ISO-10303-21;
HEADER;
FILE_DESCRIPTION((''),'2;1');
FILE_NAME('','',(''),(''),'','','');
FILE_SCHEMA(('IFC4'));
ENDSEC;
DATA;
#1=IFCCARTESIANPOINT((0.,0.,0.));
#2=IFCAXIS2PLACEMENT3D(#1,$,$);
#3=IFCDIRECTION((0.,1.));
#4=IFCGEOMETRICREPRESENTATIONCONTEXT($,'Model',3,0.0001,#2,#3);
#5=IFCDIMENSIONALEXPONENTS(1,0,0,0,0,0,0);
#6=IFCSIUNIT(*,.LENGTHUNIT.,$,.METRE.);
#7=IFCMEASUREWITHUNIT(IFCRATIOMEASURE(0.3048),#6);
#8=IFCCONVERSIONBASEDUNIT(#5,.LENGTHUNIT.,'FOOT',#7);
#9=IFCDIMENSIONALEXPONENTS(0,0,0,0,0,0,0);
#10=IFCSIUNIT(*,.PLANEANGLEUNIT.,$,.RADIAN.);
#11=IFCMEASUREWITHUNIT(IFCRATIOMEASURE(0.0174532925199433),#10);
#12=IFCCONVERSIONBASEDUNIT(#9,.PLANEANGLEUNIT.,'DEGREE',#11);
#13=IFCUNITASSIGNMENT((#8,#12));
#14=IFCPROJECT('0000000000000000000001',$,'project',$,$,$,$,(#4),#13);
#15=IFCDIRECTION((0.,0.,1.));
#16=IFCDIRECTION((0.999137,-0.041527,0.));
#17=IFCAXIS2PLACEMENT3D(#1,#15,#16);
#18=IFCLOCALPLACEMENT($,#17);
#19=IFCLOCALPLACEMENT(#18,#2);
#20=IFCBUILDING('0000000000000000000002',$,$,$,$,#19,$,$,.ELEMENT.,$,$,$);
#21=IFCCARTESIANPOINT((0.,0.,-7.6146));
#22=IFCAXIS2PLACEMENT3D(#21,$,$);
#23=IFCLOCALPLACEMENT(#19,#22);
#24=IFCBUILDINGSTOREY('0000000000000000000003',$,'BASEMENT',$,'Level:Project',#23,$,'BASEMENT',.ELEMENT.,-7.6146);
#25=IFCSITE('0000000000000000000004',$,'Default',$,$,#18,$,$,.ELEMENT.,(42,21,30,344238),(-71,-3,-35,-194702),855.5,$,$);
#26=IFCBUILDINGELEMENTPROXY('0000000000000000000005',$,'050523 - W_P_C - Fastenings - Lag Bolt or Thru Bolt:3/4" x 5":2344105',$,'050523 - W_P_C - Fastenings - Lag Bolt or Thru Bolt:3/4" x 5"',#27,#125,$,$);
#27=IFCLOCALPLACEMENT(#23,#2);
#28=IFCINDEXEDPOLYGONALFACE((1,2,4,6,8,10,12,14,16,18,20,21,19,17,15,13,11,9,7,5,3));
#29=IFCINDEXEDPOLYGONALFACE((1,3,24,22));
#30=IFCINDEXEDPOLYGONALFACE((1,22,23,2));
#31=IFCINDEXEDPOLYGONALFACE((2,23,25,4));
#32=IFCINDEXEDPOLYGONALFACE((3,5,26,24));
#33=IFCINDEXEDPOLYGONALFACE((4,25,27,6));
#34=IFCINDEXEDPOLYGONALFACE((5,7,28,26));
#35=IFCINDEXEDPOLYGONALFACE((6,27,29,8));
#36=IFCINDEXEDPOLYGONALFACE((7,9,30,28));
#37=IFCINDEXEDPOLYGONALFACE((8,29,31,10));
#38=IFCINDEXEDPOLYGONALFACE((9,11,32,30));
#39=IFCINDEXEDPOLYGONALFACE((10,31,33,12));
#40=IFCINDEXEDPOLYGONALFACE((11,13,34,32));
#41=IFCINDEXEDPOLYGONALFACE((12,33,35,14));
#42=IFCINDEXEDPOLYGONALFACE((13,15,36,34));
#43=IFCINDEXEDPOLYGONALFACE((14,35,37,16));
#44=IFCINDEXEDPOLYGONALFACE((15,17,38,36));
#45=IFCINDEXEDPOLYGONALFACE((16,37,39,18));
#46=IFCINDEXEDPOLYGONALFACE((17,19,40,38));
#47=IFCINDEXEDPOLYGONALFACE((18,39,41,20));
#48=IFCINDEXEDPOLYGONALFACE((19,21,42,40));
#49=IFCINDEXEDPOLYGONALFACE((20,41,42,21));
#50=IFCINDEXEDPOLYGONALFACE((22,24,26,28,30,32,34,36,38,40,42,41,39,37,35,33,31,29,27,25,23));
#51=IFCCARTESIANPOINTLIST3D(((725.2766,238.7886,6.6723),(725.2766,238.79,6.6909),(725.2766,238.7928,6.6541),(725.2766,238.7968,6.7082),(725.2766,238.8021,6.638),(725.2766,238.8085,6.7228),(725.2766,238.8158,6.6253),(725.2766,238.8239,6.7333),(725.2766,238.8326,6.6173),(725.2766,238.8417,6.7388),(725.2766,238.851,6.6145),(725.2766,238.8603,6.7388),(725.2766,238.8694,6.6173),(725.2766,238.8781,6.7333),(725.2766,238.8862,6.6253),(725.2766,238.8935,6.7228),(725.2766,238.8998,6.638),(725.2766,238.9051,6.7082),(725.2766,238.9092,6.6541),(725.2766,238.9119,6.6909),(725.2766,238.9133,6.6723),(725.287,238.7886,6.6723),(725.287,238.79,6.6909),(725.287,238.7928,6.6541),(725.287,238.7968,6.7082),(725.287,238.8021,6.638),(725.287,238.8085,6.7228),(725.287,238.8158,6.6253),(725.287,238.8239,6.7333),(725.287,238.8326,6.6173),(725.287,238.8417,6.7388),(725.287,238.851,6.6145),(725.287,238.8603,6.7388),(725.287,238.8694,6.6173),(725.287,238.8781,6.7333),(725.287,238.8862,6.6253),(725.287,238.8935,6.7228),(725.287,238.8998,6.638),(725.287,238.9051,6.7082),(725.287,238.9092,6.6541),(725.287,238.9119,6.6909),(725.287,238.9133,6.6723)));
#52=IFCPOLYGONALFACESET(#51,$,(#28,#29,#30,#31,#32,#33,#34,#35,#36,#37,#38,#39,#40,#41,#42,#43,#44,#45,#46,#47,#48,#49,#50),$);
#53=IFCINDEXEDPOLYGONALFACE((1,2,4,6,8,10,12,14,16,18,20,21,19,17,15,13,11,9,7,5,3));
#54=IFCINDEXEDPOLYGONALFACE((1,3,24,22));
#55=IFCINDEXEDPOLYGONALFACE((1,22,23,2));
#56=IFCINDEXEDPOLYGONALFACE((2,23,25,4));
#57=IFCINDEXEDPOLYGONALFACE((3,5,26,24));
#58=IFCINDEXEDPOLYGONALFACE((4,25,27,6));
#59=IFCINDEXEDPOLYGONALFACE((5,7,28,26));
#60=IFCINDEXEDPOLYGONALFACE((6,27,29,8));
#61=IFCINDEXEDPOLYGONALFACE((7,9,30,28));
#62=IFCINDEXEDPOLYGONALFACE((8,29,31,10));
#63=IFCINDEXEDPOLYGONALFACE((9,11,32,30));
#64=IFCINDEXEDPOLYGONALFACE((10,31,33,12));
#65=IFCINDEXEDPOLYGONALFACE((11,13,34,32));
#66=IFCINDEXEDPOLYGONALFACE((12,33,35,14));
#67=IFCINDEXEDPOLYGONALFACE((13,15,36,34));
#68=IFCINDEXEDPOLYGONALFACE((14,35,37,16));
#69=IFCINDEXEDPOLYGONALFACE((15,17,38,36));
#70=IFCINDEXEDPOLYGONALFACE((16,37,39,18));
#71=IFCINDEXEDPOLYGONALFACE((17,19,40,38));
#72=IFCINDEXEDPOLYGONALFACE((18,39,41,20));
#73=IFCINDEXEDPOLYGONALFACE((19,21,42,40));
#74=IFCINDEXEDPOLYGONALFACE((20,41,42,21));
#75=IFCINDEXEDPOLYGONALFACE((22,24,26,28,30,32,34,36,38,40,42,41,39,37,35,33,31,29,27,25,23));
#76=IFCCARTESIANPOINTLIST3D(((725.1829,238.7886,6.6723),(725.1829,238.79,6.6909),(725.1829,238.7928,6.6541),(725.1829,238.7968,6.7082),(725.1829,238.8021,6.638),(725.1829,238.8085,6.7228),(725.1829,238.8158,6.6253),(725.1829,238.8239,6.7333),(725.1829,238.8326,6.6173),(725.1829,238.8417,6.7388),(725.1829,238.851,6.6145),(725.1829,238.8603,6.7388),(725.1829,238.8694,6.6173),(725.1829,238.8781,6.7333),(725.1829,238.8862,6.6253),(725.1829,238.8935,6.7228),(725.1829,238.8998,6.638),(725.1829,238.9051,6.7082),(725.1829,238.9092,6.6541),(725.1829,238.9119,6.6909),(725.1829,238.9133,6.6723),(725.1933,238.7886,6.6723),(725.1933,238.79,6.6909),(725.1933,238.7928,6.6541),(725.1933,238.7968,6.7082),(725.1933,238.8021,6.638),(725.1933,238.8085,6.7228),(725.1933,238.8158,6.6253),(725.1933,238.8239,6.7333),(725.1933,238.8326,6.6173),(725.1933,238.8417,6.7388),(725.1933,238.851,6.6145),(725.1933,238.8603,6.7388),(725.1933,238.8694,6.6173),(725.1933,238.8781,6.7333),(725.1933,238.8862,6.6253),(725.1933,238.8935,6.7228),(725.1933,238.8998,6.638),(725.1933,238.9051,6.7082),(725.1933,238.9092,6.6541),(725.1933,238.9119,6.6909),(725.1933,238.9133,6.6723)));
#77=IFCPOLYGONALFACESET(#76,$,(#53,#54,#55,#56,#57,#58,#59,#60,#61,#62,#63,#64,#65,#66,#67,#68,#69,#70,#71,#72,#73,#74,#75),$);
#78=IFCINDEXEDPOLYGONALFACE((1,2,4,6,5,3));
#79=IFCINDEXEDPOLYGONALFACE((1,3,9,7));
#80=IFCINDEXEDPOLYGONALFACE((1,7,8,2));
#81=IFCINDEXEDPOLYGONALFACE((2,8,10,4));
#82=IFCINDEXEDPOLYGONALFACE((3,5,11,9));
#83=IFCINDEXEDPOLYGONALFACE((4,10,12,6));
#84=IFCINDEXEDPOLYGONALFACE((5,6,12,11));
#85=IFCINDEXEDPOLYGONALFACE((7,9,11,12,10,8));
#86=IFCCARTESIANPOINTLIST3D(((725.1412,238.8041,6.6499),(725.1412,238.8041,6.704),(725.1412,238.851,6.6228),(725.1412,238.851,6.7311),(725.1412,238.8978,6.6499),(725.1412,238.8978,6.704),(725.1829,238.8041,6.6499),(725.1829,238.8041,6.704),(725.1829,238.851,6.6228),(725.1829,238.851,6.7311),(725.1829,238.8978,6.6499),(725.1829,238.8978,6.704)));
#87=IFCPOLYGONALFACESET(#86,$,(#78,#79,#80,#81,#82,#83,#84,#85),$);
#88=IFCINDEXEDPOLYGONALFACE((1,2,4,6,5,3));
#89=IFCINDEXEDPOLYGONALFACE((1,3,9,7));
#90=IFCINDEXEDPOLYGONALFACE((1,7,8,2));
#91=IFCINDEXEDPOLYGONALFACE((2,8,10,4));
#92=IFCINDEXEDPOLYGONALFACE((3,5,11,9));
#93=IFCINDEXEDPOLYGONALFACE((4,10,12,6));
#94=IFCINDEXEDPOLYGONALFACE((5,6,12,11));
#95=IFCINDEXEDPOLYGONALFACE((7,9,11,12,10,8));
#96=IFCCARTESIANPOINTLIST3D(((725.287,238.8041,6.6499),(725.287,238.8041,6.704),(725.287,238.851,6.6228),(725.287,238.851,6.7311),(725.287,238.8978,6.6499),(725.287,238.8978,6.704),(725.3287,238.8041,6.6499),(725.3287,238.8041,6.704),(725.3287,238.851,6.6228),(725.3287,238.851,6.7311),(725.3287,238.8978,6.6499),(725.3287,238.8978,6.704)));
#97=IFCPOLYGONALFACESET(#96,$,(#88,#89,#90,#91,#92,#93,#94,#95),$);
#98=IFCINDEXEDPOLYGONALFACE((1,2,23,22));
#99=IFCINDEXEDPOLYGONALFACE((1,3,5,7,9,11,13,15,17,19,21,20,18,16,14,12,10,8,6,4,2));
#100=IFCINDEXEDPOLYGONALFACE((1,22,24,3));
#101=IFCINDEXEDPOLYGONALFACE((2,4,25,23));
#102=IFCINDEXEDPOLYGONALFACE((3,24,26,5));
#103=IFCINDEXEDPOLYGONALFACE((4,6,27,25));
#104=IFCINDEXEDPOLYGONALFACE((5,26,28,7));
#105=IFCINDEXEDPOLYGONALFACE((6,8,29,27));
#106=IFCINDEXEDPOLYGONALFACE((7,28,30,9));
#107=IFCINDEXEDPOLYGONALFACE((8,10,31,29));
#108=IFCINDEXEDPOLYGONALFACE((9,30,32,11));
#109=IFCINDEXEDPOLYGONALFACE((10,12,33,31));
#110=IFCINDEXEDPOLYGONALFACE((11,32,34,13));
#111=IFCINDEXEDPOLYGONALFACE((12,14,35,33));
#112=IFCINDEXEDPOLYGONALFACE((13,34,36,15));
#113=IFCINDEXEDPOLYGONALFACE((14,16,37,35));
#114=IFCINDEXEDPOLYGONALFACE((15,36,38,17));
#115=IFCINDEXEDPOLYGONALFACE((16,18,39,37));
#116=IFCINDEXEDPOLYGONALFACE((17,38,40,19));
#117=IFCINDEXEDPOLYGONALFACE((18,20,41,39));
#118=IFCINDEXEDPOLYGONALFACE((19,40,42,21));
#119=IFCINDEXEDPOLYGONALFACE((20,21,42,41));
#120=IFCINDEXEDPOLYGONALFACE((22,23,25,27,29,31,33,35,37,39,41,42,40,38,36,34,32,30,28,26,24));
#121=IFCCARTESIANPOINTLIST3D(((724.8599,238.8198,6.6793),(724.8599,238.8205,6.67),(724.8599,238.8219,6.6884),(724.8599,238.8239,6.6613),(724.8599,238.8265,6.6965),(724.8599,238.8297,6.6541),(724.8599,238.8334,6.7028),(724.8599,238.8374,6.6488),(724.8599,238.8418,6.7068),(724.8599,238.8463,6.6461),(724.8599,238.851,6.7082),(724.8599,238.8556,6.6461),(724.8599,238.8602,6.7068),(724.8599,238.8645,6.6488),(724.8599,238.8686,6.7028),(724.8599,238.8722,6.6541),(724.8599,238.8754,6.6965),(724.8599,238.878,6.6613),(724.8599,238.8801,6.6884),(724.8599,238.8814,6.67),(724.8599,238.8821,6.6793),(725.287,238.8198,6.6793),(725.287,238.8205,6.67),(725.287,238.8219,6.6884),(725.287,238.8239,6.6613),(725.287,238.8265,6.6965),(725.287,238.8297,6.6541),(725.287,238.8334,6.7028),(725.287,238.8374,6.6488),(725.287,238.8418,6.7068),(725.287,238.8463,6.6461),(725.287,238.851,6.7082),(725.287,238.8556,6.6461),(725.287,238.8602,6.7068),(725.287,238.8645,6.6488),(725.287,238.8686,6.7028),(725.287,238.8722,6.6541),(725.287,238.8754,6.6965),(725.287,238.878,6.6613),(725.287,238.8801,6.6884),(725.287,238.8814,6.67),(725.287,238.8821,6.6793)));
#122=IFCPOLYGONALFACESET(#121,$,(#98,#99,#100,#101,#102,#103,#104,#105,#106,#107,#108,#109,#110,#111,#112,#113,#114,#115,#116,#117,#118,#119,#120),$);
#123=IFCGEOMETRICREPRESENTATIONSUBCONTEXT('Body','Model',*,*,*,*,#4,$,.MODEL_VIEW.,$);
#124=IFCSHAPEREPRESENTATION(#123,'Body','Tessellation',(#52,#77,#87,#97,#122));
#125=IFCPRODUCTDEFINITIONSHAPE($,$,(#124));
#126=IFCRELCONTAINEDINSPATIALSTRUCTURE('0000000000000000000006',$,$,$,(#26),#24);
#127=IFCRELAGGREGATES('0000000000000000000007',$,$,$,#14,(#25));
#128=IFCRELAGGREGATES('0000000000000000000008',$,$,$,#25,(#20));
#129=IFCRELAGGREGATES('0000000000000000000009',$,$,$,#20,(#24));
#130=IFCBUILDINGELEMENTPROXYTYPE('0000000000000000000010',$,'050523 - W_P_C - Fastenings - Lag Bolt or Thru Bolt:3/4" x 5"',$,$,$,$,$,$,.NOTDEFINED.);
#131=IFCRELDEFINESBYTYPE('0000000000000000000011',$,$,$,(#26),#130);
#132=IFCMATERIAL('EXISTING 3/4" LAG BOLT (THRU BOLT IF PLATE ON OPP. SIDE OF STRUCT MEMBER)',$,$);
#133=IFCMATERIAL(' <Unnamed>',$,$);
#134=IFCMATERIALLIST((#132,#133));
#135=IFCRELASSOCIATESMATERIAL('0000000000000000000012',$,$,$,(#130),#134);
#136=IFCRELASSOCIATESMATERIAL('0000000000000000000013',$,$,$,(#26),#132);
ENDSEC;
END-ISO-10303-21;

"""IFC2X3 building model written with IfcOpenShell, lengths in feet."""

from ifc_helpers import new_model, entity, si_unit, converted_unit, direction, frame, frame_2d, origin, place, context, subcontext, project, spatial, polyline, circle, outline, extrude, source, transform, mapped, material, material_list, type_object, type_shapes, element, save


model = new_model("IFC2X3")

# Units and contexts
model_context = context("Model", 3, precision=0.0001, world=origin(), true_north=direction((0.0, 1.0)))
body_context = subcontext(model_context, "Body", "Model", "MODEL_VIEW")
ifc_project = project(units=[converted_unit("LENGTHUNIT", "FOOT", entity("IfcRatioMeasure", 0.3048), si_unit("LENGTHUNIT", "METRE"), dimensions=[1, 0, 0, 0, 0, 0, 0]), converted_unit("PLANEANGLEUNIT", "DEGREE", entity("IfcRatioMeasure", 0.0174532925199433), si_unit("PLANEANGLEUNIT", "RADIAN"), dimensions=[0, 0, 0, 0, 0, 0, 0])], contexts=[model_context])

# Site, building, storey
site_placement = place(None, frame((0.0, 0.0, 0.0), z_axis=(0.0, 0.0, 1.0), x_axis=(0.999137, -0.041527, 0.0)))
site = spatial("IfcSite", under=ifc_project, at=site_placement, Name="Default", CompositionType="ELEMENT", RefLatitude=(42, 21, 30, 344238), RefLongitude=(-71, -3, -35, -194702), RefElevation=855.5)
building_placement = place(site_placement, origin())
building = spatial("IfcBuilding", under=site, at=building_placement, CompositionType="ELEMENT")
storey_placement = place(building_placement, frame((0.0, 0.0, -7.6146)))
storey = spatial("IfcBuildingStorey", under=building, at=storey_placement, Name="BASEMENT", ObjectType="Level:Project", LongName="BASEMENT", CompositionType="ELEMENT", Elevation=-7.6146)

# Building element proxy
ifc_material_1 = material(Name=" <Unnamed>")
ifc_material_2 = material(Name="EXISTING 3/4\" LAG BOLT (THRU BOLT IF PLATE ON OPP. SIDE OF STRUCT MEMBER)")
ifc_material_list_1 = material_list([ifc_material_2, ifc_material_1])
building_element_proxy_type_1 = type_object("IfcBuildingElementProxyType", Name="050523 - W_P_C - Fastenings - Lag Bolt or Thru Bolt:3/4\" x 5\"", PredefinedType="NOTDEFINED", material=ifc_material_list_1)
shared_shape_1 = source(origin(), body_context, "Body", "SweptSolid", [
    extrude(circle(Radius=0.0625, at=frame_2d((0.0, 0.0), x_axis=(1.0, 0.0))), frame((0.0, 0.0, 0.0), z_axis=(0.0, 0.0, 1.0), x_axis=(0.0, 1.0, 0.0)), (0.0, 0.0, 1.0), 0.0104),
    extrude(circle(Radius=0.0625, at=frame_2d((0.0, 0.0), x_axis=(1.0, 0.0))), frame((0.0, 0.0, -0.0938), z_axis=(0.0, 0.0, 1.0), x_axis=(0.0, 1.0, 0.0)), (0.0, 0.0, 1.0), 0.0104),
    extrude(outline(polyline([(-0.0271, -0.0469), (0.0271, -0.0469), (0.0541, 0.0), (0.0271, 0.0469), (-0.0271, 0.0469), (-0.0541, 0.0), (-0.0271, -0.0469)])), frame((0.0, 0.0, -0.1354), z_axis=(0.0, 0.0, 1.0), x_axis=(0.0, -1.0, 0.0)), (0.0, 0.0, 1.0), 0.0417),
    extrude(outline(polyline([(-0.0271, -0.0469), (0.0271, -0.0469), (0.0541, 0.0), (0.0271, 0.0469), (-0.0271, 0.0469), (-0.0541, 0.0), (-0.0271, -0.0469)])), frame((0.0, 0.0, 0.0104), z_axis=(0.0, 0.0, 1.0), x_axis=(0.866025, -0.5, 0.0)), (0.0, 0.0, 1.0), 0.0417),
    extrude(circle(Radius=0.0312, at=frame_2d((0.0, 0.0), x_axis=(1.0, 0.0))), frame((0.0, 0.0, -0.4167), z_axis=(0.0, 0.0, 1.0), x_axis=(0.0, -1.0, 0.0)), (0.0, 0.0, 1.0), 0.4271),
])
type_shapes(building_element_proxy_type_1, [shared_shape_1])
for number, where, z_axis, x_axis, name in (
    (1, (725.2766, 238.851, 6.677), (1.0, 0.0, 0.0), (0.0, -1.0, 0.0), "050523 - W_P_C - Fastenings - Lag Bolt or Thru Bolt:3/4\" x 5\":2344105"),
):
    element("IfcBuildingElementProxy", number, at=place(storey_placement, frame(where, z_axis=z_axis, x_axis=x_axis)), inside=storey, type_object=building_element_proxy_type_1, material=ifc_material_2, Name=name, ObjectType="050523 - W_P_C - Fastenings - Lag Bolt or Thru Bolt:3/4\" x 5\"", context=body_context, shape_type="MappedRepresentation", body=[
        mapped(shared_shape_1, transform((0.0, 0.0, 0.0), scale=1.0)),
    ])

save(model, "model.ifc")
